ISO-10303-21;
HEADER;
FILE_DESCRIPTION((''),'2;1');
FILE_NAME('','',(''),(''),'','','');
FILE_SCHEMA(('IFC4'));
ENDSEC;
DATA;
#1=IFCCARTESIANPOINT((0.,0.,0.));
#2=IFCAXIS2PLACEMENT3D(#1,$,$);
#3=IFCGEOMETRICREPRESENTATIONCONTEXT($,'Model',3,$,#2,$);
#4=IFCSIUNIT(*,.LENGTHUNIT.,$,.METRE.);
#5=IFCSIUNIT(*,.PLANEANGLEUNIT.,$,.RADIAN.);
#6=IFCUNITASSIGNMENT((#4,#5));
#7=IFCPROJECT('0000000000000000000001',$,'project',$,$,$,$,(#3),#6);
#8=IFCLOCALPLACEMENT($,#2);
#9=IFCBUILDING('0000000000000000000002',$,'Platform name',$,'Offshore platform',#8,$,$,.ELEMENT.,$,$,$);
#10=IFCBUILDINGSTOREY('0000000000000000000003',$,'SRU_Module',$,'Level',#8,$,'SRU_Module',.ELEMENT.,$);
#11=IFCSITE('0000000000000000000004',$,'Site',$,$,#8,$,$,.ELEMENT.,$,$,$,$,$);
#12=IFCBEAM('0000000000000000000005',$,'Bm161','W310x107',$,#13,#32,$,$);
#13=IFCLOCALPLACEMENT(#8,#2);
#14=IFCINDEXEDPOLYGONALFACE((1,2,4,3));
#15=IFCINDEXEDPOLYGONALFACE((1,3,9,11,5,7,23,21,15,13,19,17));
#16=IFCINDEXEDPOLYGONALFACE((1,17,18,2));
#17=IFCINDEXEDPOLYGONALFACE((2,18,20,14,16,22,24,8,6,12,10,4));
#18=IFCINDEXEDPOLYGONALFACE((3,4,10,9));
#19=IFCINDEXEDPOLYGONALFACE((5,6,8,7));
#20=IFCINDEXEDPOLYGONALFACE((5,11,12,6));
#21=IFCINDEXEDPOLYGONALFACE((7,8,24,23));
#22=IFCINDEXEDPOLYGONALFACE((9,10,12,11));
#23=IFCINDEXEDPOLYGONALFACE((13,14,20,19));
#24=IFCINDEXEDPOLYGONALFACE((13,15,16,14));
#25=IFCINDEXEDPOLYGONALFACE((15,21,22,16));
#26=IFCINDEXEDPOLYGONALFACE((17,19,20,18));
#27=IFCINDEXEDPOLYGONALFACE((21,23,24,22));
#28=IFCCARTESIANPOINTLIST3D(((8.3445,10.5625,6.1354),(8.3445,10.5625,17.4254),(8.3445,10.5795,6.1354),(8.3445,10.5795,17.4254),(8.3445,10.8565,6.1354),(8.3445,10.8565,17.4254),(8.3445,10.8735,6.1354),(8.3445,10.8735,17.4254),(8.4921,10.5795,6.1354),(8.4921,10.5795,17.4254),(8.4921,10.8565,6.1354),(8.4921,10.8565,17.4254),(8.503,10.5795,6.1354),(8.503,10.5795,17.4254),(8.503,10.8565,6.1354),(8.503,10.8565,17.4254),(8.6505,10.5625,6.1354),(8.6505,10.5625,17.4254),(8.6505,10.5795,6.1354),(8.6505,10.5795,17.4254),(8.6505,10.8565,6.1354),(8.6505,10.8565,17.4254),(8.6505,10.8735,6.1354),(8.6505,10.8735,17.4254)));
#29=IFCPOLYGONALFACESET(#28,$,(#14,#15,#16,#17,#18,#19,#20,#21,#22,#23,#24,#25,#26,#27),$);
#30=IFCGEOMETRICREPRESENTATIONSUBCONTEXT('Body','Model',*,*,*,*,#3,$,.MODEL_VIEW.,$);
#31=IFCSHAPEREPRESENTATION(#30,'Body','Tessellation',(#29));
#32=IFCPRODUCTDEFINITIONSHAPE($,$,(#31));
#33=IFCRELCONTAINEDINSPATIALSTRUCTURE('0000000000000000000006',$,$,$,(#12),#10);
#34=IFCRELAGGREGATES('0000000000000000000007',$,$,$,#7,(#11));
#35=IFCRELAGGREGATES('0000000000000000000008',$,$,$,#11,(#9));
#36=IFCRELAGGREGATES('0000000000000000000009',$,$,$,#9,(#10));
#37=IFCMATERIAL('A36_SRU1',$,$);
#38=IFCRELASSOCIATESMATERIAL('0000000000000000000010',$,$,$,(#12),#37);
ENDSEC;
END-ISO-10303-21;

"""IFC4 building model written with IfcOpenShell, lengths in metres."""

from ifc_helpers import new_model, si_unit, frame, origin, origin_with_axes, origin_2d, place, context, subcontext, project, spatial, i_section, extrude, source, transform, mapped, material, element, save


model = new_model("IFC4")

# Units and contexts
model_context = context("Model", 3, world=origin())
body_context = subcontext(model_context, "Body", "Model", "MODEL_VIEW")
ifc_project = project(units=[si_unit("LENGTHUNIT", "METRE"), si_unit("PLANEANGLEUNIT", "RADIAN")], contexts=[model_context])

# Site, building, storey
placement_1 = place(None, origin())
site = spatial("IfcSite", under=ifc_project, at=placement_1, Name="Site", CompositionType="ELEMENT")
building = spatial("IfcBuilding", under=site, at=placement_1, Name="Platform name", ObjectType="Offshore platform", CompositionType="ELEMENT")
storey = spatial("IfcBuildingStorey", under=building, at=placement_1, Name="SRU_Module", ObjectType="Level", LongName="SRU_Module", CompositionType="ELEMENT")

# Beam
ifc_material = material(Name="A36_SRU1")
shared_shape_1 = source(origin(), body_context, "Body", "SweptSolid", [
    extrude(i_section(OverallWidth=0.306, OverallDepth=0.311, WebThickness=0.0109, FlangeThickness=0.017, FilletRadius=0.0, at=origin_2d()), origin_with_axes(), (0.0, 0.0, 1.0), 11.29),
])
placement_2 = place(None, origin())
placement_3 = place(placement_2, origin())
placement_4 = place(placement_3, origin())
beam_1_placement = place(placement_4, frame((8.4975, 10.718, 6.1354)))
element("IfcBeam", 1, at=beam_1_placement, inside=storey, material=ifc_material, Name="Bm161", Description="W310x107", context=body_context, shape_type="MappedRepresentation", body=[
    mapped(shared_shape_1, transform((0.0, 0.0, 0.0), scale=1.0)),
])

save(model, "model.ifc")
